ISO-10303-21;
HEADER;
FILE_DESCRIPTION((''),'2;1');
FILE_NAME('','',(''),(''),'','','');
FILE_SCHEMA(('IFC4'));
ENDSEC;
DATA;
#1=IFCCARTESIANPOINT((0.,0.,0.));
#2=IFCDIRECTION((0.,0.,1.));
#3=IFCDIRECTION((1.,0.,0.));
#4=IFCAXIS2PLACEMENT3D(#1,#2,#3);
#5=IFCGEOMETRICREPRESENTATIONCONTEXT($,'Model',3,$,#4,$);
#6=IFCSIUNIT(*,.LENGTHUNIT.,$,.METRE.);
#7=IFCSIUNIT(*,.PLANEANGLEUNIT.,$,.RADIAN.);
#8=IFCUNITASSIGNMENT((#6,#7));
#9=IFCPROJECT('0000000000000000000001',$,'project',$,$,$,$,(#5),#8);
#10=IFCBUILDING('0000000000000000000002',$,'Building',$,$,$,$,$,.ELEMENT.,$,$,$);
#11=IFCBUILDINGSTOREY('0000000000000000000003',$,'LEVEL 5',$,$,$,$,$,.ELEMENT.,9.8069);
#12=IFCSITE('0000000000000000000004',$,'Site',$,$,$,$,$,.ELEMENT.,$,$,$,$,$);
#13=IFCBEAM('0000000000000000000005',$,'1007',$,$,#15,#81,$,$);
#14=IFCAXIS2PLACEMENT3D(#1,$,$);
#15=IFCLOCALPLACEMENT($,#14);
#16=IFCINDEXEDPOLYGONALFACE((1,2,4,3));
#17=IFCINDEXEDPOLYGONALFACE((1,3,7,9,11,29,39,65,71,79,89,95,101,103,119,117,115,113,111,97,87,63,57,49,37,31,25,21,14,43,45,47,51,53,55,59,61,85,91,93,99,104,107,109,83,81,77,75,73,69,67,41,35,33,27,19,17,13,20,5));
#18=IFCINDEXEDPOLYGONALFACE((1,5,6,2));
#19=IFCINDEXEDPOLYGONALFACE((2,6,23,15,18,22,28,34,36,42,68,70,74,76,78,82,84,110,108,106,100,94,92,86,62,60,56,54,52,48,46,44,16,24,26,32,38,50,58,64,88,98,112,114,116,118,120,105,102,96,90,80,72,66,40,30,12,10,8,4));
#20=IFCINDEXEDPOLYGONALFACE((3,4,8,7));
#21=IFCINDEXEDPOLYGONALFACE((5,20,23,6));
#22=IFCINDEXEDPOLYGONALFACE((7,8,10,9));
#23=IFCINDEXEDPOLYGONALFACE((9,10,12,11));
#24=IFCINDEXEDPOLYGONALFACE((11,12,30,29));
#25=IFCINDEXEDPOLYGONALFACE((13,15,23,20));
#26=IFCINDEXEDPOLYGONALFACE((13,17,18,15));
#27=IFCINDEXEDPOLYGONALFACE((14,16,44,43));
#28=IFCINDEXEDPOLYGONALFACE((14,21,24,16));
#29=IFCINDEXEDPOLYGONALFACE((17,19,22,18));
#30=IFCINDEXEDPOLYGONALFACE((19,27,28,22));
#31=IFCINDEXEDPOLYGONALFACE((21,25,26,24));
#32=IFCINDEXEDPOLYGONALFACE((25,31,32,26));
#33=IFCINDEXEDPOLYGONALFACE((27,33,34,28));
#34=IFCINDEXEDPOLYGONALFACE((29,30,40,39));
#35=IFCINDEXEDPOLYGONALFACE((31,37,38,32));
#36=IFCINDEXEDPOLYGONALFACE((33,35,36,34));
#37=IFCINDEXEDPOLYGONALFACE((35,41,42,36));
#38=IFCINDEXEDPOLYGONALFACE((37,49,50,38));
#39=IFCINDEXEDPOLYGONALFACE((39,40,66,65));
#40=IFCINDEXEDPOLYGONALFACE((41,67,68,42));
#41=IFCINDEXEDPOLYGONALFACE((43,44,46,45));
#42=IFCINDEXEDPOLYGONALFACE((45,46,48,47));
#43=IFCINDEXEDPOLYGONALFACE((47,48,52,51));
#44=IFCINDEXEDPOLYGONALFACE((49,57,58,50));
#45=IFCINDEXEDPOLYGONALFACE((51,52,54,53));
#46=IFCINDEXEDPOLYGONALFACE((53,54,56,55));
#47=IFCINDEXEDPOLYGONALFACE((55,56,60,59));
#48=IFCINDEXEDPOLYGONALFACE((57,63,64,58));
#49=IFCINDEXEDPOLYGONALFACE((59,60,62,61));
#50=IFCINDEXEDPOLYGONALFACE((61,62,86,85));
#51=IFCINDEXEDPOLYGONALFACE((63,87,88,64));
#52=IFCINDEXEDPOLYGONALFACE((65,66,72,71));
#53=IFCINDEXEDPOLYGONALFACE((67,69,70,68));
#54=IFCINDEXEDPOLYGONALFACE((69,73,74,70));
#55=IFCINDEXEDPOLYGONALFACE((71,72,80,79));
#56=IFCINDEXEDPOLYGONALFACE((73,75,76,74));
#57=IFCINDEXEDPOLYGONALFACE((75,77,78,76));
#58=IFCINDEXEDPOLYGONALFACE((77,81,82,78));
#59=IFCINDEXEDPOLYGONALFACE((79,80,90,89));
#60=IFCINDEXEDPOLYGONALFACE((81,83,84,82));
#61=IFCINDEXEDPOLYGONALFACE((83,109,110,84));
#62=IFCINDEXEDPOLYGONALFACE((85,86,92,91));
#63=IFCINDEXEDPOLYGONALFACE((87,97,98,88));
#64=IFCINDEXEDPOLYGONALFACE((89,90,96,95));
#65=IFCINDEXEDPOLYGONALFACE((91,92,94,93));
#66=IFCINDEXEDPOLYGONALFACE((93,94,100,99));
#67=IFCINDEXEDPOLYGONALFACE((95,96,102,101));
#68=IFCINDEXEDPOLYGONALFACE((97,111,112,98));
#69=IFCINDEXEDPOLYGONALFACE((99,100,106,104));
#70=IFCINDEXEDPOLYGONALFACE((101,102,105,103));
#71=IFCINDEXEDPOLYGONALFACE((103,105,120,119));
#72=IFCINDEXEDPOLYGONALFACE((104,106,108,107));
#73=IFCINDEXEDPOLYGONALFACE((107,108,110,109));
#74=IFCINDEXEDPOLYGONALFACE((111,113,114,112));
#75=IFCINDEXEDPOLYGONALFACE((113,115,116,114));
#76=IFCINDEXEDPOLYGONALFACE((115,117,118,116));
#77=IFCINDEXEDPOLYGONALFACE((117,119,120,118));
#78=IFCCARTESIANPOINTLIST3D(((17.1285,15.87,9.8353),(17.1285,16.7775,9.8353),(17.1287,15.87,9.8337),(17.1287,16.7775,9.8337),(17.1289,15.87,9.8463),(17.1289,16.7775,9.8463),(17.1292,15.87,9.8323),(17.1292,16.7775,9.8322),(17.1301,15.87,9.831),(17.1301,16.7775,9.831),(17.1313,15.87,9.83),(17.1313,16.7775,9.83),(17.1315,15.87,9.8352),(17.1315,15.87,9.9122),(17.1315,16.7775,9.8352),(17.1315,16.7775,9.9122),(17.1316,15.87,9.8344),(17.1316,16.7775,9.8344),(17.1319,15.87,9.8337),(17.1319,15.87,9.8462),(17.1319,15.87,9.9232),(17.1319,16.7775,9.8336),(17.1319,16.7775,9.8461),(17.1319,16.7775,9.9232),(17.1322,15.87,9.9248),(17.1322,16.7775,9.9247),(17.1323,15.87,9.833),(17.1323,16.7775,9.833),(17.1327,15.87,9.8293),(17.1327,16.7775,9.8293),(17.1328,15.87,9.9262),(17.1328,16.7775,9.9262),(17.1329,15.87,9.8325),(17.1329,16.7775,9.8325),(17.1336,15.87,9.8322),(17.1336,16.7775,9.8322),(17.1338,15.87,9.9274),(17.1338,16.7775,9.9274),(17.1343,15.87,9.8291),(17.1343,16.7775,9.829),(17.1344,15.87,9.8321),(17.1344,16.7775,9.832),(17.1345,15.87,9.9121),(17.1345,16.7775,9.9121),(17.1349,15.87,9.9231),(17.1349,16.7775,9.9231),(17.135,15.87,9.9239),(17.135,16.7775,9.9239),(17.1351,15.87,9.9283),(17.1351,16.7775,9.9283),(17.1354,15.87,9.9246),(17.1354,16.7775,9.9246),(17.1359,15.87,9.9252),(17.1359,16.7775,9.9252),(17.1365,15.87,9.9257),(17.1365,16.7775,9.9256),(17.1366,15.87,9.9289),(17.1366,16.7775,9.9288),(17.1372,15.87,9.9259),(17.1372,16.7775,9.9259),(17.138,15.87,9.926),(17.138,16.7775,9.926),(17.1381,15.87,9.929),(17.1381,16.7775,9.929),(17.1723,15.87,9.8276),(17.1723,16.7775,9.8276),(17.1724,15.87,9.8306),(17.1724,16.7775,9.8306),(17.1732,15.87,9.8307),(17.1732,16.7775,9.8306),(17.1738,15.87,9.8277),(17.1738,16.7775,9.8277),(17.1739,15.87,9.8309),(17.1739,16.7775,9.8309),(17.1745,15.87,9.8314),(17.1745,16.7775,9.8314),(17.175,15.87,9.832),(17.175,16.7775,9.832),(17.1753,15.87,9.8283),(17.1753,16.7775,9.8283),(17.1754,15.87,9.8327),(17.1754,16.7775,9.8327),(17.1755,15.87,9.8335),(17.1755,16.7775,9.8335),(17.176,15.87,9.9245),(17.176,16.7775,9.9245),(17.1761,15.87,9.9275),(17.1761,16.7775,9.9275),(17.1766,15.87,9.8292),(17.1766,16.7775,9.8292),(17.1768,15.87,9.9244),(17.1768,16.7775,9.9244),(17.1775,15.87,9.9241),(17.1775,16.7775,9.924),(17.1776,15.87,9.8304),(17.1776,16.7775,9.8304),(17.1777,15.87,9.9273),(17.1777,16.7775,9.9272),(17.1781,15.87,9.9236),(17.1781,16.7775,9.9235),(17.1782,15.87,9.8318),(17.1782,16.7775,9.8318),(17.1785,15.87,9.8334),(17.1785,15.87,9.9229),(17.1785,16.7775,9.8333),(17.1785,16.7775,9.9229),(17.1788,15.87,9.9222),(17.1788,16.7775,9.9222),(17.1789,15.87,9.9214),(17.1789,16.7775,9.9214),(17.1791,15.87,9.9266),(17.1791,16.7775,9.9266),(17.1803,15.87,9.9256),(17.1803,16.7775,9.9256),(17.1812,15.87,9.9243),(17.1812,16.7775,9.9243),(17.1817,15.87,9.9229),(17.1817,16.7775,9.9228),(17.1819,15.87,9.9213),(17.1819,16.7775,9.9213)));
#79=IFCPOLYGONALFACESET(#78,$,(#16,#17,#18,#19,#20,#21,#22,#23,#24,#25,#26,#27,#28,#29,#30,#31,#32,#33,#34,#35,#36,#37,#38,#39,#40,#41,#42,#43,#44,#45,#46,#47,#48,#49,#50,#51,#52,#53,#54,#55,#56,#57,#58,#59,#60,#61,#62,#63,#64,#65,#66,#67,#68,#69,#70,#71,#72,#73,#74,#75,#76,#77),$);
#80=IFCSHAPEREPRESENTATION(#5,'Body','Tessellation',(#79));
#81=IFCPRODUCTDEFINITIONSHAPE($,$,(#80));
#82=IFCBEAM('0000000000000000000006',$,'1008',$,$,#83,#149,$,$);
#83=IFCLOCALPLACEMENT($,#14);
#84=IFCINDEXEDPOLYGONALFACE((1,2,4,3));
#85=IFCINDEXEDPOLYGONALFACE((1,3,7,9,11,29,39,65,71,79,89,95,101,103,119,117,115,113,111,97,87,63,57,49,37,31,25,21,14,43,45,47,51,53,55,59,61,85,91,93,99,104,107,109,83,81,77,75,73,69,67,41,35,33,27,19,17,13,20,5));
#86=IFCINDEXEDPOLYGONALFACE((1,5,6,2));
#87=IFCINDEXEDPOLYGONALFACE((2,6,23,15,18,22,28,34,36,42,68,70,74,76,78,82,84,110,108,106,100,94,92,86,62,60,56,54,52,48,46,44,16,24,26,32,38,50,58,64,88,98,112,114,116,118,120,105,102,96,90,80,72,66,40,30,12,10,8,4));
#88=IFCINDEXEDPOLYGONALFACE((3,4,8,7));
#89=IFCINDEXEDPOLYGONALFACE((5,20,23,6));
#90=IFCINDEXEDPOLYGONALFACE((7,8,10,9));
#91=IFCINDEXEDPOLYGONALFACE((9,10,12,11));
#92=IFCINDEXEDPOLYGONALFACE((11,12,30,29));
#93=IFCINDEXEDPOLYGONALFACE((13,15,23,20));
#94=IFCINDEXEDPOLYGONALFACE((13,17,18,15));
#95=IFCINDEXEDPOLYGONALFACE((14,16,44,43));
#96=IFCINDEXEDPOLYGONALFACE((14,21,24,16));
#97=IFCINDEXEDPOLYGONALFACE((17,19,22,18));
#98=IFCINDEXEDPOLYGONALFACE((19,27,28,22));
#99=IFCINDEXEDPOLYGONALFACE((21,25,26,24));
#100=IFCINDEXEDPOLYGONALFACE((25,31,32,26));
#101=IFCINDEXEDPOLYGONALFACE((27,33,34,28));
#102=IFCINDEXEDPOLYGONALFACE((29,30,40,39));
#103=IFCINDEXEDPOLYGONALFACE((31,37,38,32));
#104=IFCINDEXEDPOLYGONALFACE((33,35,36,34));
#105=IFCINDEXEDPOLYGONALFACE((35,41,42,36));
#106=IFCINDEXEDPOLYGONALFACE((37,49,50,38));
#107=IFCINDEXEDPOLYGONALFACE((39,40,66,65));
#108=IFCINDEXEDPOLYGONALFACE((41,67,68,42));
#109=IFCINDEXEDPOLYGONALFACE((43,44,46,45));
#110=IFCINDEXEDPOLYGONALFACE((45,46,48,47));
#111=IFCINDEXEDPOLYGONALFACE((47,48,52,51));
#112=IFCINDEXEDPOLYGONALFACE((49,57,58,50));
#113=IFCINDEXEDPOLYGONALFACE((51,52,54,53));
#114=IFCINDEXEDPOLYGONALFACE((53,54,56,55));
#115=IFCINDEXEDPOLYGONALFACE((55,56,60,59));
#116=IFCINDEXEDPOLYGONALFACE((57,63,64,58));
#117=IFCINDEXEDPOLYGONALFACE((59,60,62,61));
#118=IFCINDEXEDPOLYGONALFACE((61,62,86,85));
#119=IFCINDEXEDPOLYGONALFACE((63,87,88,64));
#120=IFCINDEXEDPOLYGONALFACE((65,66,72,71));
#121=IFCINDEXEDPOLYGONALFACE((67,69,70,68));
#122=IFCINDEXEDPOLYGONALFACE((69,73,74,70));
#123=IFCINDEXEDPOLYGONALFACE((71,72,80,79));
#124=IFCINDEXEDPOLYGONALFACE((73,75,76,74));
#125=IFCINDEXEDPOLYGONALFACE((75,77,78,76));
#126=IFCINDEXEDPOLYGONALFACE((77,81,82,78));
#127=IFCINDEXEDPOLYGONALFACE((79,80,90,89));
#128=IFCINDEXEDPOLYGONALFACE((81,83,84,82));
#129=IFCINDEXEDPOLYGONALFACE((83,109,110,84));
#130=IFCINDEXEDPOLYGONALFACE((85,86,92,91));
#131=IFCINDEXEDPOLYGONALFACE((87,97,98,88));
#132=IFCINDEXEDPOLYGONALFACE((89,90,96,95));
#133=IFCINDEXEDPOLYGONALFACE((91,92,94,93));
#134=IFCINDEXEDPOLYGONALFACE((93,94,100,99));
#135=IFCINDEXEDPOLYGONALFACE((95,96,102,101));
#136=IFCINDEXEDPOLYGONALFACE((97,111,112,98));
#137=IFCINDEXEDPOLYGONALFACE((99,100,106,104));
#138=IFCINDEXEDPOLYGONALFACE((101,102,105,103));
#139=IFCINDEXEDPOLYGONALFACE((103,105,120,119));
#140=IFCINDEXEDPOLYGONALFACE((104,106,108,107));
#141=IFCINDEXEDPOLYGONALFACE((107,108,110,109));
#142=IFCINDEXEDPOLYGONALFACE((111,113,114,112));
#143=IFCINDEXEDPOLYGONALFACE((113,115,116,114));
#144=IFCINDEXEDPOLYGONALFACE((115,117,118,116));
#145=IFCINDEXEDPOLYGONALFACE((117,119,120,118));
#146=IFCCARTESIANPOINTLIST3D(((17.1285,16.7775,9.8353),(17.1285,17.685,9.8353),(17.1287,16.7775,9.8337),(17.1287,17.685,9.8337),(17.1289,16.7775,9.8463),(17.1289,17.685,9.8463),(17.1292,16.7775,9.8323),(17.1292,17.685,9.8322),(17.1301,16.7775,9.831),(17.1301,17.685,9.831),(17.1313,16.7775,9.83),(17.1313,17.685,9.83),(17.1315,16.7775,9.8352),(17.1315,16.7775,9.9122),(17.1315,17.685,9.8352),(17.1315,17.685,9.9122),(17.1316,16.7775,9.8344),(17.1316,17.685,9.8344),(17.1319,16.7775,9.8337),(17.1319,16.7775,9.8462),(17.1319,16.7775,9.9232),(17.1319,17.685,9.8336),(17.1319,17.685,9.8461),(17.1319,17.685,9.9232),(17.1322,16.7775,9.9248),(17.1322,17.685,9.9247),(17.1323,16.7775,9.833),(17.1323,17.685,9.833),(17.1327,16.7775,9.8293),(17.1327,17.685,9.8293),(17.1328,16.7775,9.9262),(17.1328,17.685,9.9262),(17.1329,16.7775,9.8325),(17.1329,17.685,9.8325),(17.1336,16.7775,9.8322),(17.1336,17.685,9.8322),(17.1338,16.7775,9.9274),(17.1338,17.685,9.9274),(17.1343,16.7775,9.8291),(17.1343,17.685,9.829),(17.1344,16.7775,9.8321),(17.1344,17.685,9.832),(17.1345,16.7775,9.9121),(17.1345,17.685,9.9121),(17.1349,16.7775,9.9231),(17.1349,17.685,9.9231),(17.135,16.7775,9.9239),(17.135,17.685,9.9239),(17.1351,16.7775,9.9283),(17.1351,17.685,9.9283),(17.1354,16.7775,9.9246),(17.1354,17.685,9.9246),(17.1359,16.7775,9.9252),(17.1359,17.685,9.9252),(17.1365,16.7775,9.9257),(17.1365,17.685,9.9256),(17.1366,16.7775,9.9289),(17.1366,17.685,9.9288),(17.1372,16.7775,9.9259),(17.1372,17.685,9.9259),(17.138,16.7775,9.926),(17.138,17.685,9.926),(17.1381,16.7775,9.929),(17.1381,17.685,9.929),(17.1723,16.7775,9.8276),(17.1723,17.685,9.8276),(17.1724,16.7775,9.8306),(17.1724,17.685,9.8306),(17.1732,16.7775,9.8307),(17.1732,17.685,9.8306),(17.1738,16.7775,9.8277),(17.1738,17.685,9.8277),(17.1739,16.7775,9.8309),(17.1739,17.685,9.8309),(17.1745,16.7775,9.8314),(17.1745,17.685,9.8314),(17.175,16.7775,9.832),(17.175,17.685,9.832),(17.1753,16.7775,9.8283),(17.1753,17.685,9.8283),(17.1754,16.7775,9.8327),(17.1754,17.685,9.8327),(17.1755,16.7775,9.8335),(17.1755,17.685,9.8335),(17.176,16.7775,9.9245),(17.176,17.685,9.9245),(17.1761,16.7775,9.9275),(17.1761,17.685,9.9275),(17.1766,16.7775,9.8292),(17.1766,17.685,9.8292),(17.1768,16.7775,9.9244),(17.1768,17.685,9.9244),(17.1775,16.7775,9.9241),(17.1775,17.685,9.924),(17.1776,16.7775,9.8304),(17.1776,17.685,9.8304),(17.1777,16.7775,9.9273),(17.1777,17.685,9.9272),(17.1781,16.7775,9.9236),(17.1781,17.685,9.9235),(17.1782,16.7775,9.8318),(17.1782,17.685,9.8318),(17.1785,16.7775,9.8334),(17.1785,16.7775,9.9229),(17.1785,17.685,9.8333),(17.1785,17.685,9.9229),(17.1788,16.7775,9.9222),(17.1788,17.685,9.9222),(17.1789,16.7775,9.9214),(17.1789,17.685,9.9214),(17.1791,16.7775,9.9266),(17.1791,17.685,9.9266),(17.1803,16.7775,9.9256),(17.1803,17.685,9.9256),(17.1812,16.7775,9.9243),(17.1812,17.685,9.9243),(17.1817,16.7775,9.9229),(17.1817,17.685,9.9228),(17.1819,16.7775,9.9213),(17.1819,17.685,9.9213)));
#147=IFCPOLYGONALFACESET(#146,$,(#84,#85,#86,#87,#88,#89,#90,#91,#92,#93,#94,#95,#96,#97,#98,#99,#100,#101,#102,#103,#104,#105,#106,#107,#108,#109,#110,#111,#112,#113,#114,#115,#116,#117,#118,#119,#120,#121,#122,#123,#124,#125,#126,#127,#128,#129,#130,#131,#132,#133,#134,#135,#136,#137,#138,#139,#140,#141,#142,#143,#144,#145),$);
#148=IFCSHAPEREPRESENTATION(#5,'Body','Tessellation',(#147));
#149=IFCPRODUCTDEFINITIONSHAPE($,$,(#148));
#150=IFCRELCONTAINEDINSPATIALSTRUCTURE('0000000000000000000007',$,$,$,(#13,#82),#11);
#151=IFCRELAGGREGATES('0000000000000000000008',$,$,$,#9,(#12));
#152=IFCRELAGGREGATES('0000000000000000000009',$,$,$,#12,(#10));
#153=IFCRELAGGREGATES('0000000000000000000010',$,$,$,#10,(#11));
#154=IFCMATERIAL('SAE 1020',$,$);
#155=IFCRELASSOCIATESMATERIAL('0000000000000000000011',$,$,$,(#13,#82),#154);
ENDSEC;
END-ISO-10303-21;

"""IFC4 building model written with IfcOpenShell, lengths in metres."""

from ifc_helpers import new_model, si_unit, frame, origin_with_axes, origin_2d_with_axis, place, context, project, spatial, c_section, extrude, material, material_profile, profile_set, profile_usage, element, save


model = new_model("IFC4")

# Units and contexts
model_context = context("Model", 3, world=origin_with_axes())
ifc_project = project(units=[si_unit("LENGTHUNIT", "METRE"), si_unit("PLANEANGLEUNIT", "RADIAN")], contexts=[model_context])

# Site, building, storey
site = spatial("IfcSite", under=ifc_project, Name="Site", CompositionType="ELEMENT")
building = spatial("IfcBuilding", under=site, Name="Building", CompositionType="ELEMENT")
storey = spatial("IfcBuildingStorey", under=building, Name="LEVEL 5", CompositionType="ELEMENT", Elevation=9.8069)

# Beams
ifc_material = material(Name="SAE 1020")
ifc_material_profile_1 = material_profile(ifc_material, c_section(Depth=0.1, Width=0.05, WallThickness=0.003, Girth=0.017, InternalFilletRadius=0.003, at=origin_2d_with_axis()))
ifc_profile_set_1 = profile_set([ifc_material_profile_1])
ifc_profile_usage_1 = profile_usage(ifc_profile_set_1, cardinal=10)
beam_1_placement = place(None, frame((17.1552, 15.87, 9.8783), z_axis=(0.0, 1.0, -0.00003), x_axis=(-0.999256, 0.000001, 0.038562)))
element("IfcBeam", 1, at=beam_1_placement, inside=storey, material=ifc_profile_usage_1, Name="1007", context=model_context, shape_type="SweptSolid", body=[
    extrude(c_section(Depth=0.1, Width=0.05, WallThickness=0.003, Girth=0.017, InternalFilletRadius=0.003, at=origin_2d_with_axis()), origin_with_axes(), (0.0, 0.0, 1.0), 0.9075),
])
ifc_material_profile_2 = material_profile(ifc_material, c_section(Depth=0.1, Width=0.05, WallThickness=0.003, Girth=0.017, InternalFilletRadius=0.003, at=origin_2d_with_axis()))
ifc_profile_set_2 = profile_set([ifc_material_profile_2])
ifc_profile_usage_2 = profile_usage(ifc_profile_set_2, cardinal=10)
beam_2_placement = place(None, frame((17.1552, 16.7775, 9.8783), z_axis=(0.0, 1.0, -0.00003), x_axis=(-0.999256, 0.000001, 0.038562)))
element("IfcBeam", 2, at=beam_2_placement, inside=storey, material=ifc_profile_usage_2, Name="1008", context=model_context, shape_type="SweptSolid", body=[
    extrude(c_section(Depth=0.1, Width=0.05, WallThickness=0.003, Girth=0.017, InternalFilletRadius=0.003, at=origin_2d_with_axis()), origin_with_axes(), (0.0, 0.0, 1.0), 0.9075),
])

save(model, "model.ifc")
